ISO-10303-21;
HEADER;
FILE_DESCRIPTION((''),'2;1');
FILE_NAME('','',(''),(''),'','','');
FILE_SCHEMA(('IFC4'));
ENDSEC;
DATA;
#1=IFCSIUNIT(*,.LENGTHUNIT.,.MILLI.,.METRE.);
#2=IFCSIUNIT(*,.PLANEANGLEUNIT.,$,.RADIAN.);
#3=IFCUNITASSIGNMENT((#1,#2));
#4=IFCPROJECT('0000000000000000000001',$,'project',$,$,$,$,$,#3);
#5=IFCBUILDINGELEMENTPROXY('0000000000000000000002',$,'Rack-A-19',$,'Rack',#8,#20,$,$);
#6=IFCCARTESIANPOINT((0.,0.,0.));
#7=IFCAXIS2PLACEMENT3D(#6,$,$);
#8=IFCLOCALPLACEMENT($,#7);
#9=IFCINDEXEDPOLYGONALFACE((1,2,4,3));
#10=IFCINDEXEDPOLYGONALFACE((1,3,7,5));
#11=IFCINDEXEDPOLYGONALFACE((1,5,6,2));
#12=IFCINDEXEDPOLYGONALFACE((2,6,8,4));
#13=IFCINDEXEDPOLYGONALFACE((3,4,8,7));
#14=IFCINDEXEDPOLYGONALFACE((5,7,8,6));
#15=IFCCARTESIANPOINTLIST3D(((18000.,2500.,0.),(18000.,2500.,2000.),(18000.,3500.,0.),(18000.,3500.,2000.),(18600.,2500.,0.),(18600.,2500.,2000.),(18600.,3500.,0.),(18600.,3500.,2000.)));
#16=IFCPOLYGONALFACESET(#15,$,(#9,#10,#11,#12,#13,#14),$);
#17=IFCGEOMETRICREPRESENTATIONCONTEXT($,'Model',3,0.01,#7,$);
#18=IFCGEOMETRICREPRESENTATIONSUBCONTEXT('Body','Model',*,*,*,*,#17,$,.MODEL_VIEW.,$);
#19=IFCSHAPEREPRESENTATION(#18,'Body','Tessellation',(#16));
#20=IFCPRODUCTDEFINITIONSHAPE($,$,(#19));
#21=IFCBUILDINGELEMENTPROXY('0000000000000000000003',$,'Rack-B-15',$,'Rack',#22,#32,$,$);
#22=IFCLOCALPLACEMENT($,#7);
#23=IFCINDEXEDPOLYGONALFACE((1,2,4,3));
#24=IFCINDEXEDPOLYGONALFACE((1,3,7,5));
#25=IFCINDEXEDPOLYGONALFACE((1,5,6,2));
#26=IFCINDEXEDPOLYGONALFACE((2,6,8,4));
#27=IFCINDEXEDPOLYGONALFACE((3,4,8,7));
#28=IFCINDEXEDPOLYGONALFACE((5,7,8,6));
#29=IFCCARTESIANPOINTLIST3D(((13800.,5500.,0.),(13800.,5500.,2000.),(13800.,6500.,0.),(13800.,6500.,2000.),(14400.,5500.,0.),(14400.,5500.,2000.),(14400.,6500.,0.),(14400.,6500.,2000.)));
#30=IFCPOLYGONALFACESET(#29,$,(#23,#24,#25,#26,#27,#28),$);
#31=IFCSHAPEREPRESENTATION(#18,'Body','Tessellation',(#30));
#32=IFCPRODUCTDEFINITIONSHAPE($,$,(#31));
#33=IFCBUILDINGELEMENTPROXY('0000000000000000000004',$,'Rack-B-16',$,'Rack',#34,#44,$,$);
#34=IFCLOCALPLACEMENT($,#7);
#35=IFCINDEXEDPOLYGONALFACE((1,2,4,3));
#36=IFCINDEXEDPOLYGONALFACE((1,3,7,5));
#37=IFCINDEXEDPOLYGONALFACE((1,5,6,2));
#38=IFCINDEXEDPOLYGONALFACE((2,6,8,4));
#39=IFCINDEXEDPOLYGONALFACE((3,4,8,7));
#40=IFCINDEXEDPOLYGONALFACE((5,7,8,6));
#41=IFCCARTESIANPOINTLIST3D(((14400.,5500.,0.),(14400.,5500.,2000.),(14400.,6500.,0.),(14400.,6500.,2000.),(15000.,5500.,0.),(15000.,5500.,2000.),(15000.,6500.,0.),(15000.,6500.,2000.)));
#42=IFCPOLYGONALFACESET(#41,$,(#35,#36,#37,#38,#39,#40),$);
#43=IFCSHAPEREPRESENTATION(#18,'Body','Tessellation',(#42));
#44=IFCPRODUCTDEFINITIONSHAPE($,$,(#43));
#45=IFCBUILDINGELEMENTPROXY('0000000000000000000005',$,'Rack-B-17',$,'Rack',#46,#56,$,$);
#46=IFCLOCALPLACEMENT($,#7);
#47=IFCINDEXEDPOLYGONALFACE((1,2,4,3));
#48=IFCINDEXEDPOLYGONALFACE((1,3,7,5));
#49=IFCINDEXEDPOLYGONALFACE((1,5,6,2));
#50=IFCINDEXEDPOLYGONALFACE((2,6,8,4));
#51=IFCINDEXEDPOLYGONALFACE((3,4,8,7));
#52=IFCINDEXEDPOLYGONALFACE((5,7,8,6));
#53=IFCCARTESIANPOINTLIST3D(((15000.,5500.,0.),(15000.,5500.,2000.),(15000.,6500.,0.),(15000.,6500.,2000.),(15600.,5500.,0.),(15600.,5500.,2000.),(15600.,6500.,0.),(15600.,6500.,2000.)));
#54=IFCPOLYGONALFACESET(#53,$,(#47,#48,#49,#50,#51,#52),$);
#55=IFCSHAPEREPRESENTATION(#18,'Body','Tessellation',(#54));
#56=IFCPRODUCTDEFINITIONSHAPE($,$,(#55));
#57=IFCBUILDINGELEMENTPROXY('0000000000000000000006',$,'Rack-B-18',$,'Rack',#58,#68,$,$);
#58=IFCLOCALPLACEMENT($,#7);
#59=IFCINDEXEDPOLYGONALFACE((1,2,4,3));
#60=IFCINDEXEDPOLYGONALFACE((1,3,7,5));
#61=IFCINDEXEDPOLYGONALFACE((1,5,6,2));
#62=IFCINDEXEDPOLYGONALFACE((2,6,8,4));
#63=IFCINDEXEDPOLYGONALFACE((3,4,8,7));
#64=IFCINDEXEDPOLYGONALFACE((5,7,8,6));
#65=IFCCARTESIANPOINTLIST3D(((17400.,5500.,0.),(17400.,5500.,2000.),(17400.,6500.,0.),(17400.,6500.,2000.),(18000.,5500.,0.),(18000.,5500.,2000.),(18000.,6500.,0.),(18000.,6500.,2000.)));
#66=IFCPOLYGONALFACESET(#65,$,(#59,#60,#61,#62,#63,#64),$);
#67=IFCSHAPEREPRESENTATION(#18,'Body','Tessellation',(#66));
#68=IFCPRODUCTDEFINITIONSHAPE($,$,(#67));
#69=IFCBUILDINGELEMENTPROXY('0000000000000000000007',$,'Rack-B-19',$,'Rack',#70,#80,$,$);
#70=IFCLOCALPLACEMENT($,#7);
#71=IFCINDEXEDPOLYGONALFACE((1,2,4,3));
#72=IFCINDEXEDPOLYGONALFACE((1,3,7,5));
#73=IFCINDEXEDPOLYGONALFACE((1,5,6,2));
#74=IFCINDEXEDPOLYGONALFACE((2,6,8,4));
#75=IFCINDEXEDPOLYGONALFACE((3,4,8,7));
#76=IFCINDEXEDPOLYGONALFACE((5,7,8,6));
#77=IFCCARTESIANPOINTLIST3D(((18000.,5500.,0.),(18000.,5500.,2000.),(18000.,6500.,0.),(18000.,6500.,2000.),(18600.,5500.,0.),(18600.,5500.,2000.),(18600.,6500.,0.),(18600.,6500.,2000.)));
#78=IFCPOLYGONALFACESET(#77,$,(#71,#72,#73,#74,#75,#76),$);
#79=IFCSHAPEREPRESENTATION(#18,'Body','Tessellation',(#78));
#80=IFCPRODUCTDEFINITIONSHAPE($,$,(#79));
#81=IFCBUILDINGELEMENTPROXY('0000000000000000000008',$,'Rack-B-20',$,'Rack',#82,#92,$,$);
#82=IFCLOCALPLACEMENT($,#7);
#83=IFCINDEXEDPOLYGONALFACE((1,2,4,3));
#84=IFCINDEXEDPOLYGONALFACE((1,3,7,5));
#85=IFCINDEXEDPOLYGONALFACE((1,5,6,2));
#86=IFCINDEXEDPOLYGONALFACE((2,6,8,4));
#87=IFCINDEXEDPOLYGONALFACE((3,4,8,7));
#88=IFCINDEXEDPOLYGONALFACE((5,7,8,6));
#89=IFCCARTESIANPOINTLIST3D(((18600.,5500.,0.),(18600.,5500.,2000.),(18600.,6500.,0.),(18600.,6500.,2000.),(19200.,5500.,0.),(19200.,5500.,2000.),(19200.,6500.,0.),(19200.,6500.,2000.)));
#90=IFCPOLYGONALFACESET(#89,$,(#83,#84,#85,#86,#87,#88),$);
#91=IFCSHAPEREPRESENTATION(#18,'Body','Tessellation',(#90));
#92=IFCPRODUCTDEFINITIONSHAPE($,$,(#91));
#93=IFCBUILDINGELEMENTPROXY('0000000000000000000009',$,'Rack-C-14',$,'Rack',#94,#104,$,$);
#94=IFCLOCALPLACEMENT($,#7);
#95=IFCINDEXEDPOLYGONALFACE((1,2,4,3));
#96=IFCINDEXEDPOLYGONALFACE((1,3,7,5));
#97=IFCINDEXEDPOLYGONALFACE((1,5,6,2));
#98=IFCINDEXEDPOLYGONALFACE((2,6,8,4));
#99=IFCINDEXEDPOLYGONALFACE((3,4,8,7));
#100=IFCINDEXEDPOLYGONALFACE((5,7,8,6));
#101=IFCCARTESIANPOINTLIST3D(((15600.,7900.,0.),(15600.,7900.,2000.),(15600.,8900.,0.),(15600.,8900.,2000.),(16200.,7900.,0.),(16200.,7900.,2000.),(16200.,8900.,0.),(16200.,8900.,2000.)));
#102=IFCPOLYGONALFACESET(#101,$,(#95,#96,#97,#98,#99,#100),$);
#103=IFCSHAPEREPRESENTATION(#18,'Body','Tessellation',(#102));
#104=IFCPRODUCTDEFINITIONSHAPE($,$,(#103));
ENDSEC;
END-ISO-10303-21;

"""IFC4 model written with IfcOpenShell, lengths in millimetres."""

from ifc_helpers import new_model, si_unit, frame, origin, place, context, subcontext, project, rectangle, extrude, element, save


model = new_model("IFC4")

# Units and contexts
model_context = context("Model", 3, precision=0.01, world=origin())
body_context = subcontext(model_context, "Body", "Model", "MODEL_VIEW")
ifc_project = project(units=[si_unit("LENGTHUNIT", "METRE", prefix="MILLI"), si_unit("PLANEANGLEUNIT", "RADIAN")])

# Shared definitions
placement = place(None, origin())

# Building element proxies
for number, where, name in (
    (1, (18300.0, 3000.0, 0.0), "Rack-A-19"),
    (2, (14100.0, 6000.0, 0.0), "Rack-B-15"),
    (3, (14700.0, 6000.0, 0.0), "Rack-B-16"),
    (4, (15300.0, 6000.0, 0.0), "Rack-B-17"),
    (5, (17700.0, 6000.0, 0.0), "Rack-B-18"),
    (6, (18300.0, 6000.0, 0.0), "Rack-B-19"),
    (7, (18900.0, 6000.0, 0.0), "Rack-B-20"),
    (8, (15900.0, 8400.0, 0.0), "Rack-C-14"),
):
    element("IfcBuildingElementProxy", number, at=place(placement, frame(where)), Name=name, ObjectType="Rack", context=body_context, shape_type="SweptSolid", body=[
        extrude(rectangle(XDim=600.0, YDim=1000.0), origin(), (0.0, 0.0, 1.0), 2000.0),
    ])

save(model, "model.ifc")
